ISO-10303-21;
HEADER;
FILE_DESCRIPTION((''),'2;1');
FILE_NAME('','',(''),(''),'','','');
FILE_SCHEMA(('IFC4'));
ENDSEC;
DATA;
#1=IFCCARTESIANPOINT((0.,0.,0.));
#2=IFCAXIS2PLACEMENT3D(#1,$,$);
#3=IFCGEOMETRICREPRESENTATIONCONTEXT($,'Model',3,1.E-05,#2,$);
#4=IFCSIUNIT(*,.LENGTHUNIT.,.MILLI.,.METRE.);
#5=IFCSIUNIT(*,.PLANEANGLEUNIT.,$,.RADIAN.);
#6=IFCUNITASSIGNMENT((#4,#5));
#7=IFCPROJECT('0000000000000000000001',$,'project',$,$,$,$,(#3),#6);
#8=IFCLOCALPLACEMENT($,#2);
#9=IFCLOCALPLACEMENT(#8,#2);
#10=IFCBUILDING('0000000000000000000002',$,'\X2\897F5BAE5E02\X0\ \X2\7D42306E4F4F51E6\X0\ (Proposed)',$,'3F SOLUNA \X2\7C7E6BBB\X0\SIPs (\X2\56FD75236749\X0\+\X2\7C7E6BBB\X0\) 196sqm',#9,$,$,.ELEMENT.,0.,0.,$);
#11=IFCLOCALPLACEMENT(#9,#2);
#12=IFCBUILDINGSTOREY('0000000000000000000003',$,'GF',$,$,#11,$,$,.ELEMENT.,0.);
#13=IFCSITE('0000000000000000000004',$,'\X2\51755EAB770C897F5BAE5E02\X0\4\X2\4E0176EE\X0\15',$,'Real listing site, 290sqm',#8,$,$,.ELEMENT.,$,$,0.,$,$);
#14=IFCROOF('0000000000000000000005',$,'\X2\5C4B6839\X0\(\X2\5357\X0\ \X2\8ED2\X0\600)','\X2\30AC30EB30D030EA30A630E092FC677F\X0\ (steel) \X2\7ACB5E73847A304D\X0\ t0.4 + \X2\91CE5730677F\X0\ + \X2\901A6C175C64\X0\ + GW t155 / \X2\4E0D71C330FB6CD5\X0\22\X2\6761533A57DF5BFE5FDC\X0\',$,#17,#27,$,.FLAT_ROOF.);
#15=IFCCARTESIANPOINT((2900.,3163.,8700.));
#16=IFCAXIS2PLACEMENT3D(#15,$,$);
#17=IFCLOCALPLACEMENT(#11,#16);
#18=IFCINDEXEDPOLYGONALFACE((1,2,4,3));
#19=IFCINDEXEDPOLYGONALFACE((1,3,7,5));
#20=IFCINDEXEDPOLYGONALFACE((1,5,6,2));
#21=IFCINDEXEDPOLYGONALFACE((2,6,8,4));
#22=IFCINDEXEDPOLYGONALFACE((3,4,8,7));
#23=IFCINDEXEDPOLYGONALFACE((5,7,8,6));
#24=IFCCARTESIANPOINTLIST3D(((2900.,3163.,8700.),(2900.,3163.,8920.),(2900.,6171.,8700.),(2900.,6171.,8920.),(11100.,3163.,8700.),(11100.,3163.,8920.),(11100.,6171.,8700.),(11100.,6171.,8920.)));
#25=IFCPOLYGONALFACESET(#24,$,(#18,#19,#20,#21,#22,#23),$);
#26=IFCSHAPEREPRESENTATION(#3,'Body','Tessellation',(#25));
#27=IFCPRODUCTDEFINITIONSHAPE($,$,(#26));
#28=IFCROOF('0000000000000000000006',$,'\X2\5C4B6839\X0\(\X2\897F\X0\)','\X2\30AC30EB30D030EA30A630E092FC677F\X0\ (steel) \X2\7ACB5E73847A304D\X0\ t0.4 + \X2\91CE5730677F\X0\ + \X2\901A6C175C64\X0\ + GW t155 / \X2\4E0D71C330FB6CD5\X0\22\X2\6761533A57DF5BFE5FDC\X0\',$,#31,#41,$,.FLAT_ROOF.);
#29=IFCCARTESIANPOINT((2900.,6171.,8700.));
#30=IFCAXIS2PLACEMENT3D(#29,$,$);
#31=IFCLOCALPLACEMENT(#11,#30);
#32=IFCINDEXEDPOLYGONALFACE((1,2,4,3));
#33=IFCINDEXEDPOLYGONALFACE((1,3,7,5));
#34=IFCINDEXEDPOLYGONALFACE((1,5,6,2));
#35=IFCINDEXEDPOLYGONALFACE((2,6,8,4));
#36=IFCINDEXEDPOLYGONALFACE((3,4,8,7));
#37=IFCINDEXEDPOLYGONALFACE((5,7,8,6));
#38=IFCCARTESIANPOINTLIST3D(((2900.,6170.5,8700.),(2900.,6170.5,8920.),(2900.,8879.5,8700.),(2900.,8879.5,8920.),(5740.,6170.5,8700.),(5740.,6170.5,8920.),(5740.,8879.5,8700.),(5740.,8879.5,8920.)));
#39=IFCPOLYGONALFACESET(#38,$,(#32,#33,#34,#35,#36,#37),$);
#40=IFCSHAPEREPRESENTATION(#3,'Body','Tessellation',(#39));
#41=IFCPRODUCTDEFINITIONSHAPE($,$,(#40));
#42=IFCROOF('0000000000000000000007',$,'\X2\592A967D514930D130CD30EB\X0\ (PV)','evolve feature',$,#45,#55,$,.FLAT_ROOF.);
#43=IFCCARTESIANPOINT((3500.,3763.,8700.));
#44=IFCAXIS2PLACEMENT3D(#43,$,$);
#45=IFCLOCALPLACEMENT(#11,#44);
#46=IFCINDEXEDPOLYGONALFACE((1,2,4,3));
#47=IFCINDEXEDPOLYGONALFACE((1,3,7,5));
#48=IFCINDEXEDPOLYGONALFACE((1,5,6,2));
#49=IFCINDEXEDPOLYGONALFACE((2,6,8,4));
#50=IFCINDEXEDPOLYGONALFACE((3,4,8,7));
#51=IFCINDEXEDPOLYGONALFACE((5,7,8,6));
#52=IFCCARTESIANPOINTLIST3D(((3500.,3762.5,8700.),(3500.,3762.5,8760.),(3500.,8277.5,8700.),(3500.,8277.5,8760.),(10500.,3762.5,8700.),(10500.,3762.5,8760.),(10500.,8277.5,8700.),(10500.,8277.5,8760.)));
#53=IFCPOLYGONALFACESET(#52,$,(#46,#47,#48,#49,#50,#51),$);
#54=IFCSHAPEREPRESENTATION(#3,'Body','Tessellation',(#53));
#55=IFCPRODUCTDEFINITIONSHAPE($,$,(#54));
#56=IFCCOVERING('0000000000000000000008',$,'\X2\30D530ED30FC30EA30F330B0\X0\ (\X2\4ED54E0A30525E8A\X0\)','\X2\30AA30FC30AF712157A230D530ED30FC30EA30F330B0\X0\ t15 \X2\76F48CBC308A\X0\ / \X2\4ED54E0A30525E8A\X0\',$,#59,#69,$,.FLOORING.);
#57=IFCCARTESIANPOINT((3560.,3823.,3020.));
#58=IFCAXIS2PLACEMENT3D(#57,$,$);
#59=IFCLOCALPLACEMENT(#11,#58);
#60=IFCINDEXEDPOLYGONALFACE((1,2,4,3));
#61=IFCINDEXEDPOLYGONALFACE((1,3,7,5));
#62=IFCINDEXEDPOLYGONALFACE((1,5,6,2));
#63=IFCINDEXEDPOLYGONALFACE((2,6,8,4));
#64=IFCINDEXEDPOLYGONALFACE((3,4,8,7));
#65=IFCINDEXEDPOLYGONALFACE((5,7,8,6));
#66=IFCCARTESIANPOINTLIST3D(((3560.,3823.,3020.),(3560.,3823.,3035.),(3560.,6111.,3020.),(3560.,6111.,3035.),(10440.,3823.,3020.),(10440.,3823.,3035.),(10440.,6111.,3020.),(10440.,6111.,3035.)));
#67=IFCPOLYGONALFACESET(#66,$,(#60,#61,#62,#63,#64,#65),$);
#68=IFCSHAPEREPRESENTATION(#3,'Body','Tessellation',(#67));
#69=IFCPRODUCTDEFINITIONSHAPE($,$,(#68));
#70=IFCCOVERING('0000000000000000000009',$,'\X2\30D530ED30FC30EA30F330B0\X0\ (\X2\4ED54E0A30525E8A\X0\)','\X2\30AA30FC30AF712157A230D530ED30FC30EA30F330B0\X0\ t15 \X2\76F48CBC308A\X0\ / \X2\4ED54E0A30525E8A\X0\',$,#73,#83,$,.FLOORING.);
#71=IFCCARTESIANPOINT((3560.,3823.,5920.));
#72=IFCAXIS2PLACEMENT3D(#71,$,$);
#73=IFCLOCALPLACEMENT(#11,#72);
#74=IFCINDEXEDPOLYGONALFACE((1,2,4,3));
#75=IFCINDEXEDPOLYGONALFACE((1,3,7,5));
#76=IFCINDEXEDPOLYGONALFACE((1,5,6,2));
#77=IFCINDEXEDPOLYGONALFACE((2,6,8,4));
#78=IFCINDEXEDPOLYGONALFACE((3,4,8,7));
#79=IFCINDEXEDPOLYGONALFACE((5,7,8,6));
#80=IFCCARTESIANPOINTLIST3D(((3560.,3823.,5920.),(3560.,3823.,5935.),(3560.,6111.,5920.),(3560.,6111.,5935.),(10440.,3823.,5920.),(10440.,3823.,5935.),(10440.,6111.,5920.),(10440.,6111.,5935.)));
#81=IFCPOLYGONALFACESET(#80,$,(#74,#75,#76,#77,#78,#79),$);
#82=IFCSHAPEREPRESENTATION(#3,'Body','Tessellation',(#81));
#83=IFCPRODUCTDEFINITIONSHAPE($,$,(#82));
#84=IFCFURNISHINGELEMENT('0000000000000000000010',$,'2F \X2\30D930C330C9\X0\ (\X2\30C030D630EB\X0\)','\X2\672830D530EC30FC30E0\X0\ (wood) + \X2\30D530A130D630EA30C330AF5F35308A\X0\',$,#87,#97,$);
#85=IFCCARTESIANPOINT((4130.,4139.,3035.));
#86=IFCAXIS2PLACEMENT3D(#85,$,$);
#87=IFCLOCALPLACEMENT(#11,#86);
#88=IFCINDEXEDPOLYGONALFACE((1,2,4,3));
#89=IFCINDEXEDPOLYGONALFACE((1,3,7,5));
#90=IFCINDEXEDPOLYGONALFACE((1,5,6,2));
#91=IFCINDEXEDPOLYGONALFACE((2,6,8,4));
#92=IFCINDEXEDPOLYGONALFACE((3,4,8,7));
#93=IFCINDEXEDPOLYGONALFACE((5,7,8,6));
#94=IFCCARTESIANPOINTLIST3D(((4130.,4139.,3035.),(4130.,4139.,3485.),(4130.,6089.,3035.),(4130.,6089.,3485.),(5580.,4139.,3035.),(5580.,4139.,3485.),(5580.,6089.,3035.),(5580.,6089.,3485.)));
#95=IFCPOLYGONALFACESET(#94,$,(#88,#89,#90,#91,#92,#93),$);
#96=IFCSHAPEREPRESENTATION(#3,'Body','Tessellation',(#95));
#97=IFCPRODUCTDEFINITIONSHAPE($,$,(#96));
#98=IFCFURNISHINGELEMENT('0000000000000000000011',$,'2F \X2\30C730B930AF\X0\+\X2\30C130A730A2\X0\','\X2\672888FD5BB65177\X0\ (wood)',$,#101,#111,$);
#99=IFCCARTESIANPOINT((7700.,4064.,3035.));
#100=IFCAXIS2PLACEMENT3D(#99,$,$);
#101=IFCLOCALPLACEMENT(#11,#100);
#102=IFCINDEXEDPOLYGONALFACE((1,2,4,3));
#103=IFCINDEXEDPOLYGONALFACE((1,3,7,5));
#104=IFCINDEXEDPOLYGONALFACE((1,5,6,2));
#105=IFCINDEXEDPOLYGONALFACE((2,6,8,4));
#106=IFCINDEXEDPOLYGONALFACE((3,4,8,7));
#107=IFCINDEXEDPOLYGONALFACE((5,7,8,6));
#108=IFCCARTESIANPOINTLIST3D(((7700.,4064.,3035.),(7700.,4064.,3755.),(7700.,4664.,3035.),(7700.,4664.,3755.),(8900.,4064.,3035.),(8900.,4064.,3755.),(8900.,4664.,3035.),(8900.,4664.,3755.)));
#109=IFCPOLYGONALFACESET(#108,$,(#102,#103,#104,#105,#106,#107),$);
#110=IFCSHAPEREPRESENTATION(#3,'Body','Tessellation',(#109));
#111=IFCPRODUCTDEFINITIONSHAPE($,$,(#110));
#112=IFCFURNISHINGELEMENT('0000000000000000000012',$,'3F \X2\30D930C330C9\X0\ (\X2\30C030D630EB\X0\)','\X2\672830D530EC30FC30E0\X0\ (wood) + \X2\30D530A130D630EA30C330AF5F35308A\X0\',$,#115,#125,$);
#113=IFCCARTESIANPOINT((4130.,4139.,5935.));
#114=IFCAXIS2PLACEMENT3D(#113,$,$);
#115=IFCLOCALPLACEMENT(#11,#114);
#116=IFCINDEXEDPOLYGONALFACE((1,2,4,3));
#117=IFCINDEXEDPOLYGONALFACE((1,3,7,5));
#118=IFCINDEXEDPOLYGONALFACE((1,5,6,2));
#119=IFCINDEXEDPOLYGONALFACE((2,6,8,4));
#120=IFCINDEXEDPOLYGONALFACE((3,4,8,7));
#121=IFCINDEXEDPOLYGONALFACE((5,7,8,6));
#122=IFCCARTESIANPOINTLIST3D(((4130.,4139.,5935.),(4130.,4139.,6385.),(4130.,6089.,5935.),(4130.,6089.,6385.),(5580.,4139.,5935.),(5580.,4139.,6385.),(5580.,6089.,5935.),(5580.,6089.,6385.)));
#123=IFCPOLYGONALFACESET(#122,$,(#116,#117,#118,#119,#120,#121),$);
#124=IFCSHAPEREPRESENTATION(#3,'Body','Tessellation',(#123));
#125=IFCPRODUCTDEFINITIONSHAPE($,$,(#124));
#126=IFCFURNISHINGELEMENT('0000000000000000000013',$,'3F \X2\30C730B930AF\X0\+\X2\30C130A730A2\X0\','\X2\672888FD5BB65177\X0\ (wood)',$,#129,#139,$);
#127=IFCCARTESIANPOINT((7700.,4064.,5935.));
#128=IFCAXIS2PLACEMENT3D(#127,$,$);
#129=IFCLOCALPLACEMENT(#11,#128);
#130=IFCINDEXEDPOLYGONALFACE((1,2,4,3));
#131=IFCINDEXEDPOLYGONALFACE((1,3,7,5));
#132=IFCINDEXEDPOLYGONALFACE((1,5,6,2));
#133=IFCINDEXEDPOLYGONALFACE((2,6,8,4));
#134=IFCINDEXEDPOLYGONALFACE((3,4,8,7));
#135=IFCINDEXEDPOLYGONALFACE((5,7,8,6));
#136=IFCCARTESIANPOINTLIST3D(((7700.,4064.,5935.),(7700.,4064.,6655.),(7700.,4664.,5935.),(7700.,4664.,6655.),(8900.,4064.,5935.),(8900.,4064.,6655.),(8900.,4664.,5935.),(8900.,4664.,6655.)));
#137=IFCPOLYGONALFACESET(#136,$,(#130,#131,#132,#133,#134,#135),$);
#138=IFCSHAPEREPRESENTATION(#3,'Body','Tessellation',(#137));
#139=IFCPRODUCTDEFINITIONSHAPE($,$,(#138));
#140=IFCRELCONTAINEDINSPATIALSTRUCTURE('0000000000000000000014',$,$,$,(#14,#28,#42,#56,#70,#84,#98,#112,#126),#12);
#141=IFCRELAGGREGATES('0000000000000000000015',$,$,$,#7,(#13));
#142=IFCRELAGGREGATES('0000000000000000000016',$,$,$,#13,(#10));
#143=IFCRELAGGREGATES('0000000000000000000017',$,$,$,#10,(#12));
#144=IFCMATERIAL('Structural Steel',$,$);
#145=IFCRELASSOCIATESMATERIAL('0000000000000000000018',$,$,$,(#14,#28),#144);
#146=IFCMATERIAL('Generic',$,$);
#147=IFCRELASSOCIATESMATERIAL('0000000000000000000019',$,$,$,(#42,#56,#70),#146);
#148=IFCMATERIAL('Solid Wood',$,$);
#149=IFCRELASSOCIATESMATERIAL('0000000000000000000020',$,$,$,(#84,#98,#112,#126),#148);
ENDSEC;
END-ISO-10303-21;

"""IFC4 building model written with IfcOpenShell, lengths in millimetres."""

from ifc_helpers import new_model, si_unit, frame, frame_2d, origin, place, context, project, spatial, rectangle, extrude, material, element, save


model = new_model("IFC4")

# Units and contexts
model_context = context("Model", 3, precision=1e-05, world=origin())
ifc_project = project(units=[si_unit("LENGTHUNIT", "METRE", prefix="MILLI"), si_unit("PLANEANGLEUNIT", "RADIAN")], contexts=[model_context])

# Site, building, storey
site_placement = place(None, origin())
site = spatial("IfcSite", under=ifc_project, at=site_placement, Name="兵庫県西宮市4丁目15", ObjectType="Real listing site, 290sqm", CompositionType="ELEMENT", RefElevation=0.0)
building_placement = place(site_placement, origin())
building = spatial("IfcBuilding", under=site, at=building_placement, Name="西宮市 終の住処 (Proposed)", ObjectType="3F SOLUNA 籾殻SIPs (国産杉+籾殻) 196sqm", CompositionType="ELEMENT", ElevationOfRefHeight=0.0, ElevationOfTerrain=0.0)
storey_placement = place(building_placement, origin())
storey = spatial("IfcBuildingStorey", under=building, at=storey_placement, Name="GF", CompositionType="ELEMENT", Elevation=0.0)

# Shared definitions
ifc_material_1 = material(Name="Solid Wood")

# Roofs
ifc_material_2 = material(Name="Structural Steel")
roof_1_placement = place(storey_placement, frame((2900.0, 3163.0, 8700.0)))
element("IfcRoof", 1, at=roof_1_placement, inside=storey, material=ifc_material_2, Name="屋根(南 軒600)", Description="ガルバリウム鋼板 (steel) 立平葺き t0.4 + 野地板 + 通気層 + GW t155 / 不燃・法22条区域対応", PredefinedType="FLAT_ROOF", context=model_context, shape_type="SweptSolid", body=[
    extrude(rectangle(XDim=8200.0, YDim=3008.0, at=frame_2d((4100.0, 1504.0))), frame((2900.0, 3163.0, 8700.0)), (0.0, 0.0, 1.0), 220.0),
])
roof_2_placement = place(storey_placement, frame((2900.0, 6171.0, 8700.0)))
element("IfcRoof", 2, at=roof_2_placement, inside=storey, material=ifc_material_2, Name="屋根(西)", Description="ガルバリウム鋼板 (steel) 立平葺き t0.4 + 野地板 + 通気層 + GW t155 / 不燃・法22条区域対応", PredefinedType="FLAT_ROOF", context=model_context, shape_type="SweptSolid", body=[
    extrude(rectangle(XDim=2840.0, YDim=2709.0, at=frame_2d((1420.0, 1354.0))), frame((2900.0, 6171.0, 8700.0)), (0.0, 0.0, 1.0), 220.0),
])
ifc_material_3 = material(Name="Generic")
roof_3_placement = place(storey_placement, frame((3500.0, 3763.0, 8700.0)))
element("IfcRoof", 3, at=roof_3_placement, inside=storey, material=ifc_material_3, Name="太陽光パネル (PV)", Description="evolve feature", PredefinedType="FLAT_ROOF", context=model_context, shape_type="SweptSolid", body=[
    extrude(rectangle(XDim=7000.0, YDim=4515.0, at=frame_2d((3500.0, 2257.0))), frame((3500.0, 3763.0, 8700.0)), (0.0, 0.0, 1.0), 60.0),
])

# Coverings
covering_1_placement = place(storey_placement, frame((3560.0, 3823.0, 3020.0)))
element("IfcCovering", 4, at=covering_1_placement, inside=storey, material=ifc_material_3, Name="フローリング (仕上げ床)", Description="オーク無垢フローリング t15 直貼り / 仕上げ床", PredefinedType="FLOORING", context=model_context, shape_type="SweptSolid", body=[
    extrude(rectangle(XDim=6880.0, YDim=2288.0, at=frame_2d((3440.0, 1144.0))), frame((3560.0, 3823.0, 3020.0)), (0.0, 0.0, 1.0), 15.0),
])
covering_2_placement = place(storey_placement, frame((3560.0, 3823.0, 5920.0)))
element("IfcCovering", 5, at=covering_2_placement, inside=storey, material=ifc_material_3, Name="フローリング (仕上げ床)", Description="オーク無垢フローリング t15 直貼り / 仕上げ床", PredefinedType="FLOORING", context=model_context, shape_type="SweptSolid", body=[
    extrude(rectangle(XDim=6880.0, YDim=2288.0, at=frame_2d((3440.0, 1144.0))), frame((3560.0, 3823.0, 5920.0)), (0.0, 0.0, 1.0), 15.0),
])

# Furnishing elements
furnishing_1_placement = place(storey_placement, frame((4130.0, 4139.0, 3035.0)))
element("IfcFurnishingElement", 6, at=furnishing_1_placement, inside=storey, material=ifc_material_1, Name="2F ベッド (ダブル)", Description="木フレーム (wood) + ファブリック張り", context=model_context, shape_type="SweptSolid", body=[
    extrude(rectangle(XDim=1450.0, YDim=1950.0, at=frame_2d((725.0, 975.0))), frame((4130.0, 4139.0, 3035.0)), (0.0, 0.0, 1.0), 450.0),
])
furnishing_2_placement = place(storey_placement, frame((7700.0, 4064.0, 3035.0)))
element("IfcFurnishingElement", 7, at=furnishing_2_placement, inside=storey, material=ifc_material_1, Name="2F デスク+チェア", Description="木製家具 (wood)", context=model_context, shape_type="SweptSolid", body=[
    extrude(rectangle(XDim=1200.0, YDim=600.0, at=frame_2d((600.0, 300.0))), frame((7700.0, 4064.0, 3035.0)), (0.0, 0.0, 1.0), 720.0),
])
furnishing_3_placement = place(storey_placement, frame((4130.0, 4139.0, 5935.0)))
element("IfcFurnishingElement", 8, at=furnishing_3_placement, inside=storey, material=ifc_material_1, Name="3F ベッド (ダブル)", Description="木フレーム (wood) + ファブリック張り", context=model_context, shape_type="SweptSolid", body=[
    extrude(rectangle(XDim=1450.0, YDim=1950.0, at=frame_2d((725.0, 975.0))), frame((4130.0, 4139.0, 5935.0)), (0.0, 0.0, 1.0), 450.0),
])
furnishing_4_placement = place(storey_placement, frame((7700.0, 4064.0, 5935.0)))
element("IfcFurnishingElement", 9, at=furnishing_4_placement, inside=storey, material=ifc_material_1, Name="3F デスク+チェア", Description="木製家具 (wood)", context=model_context, shape_type="SweptSolid", body=[
    extrude(rectangle(XDim=1200.0, YDim=600.0, at=frame_2d((600.0, 300.0))), frame((7700.0, 4064.0, 5935.0)), (0.0, 0.0, 1.0), 720.0),
])

save(model, "model.ifc")
